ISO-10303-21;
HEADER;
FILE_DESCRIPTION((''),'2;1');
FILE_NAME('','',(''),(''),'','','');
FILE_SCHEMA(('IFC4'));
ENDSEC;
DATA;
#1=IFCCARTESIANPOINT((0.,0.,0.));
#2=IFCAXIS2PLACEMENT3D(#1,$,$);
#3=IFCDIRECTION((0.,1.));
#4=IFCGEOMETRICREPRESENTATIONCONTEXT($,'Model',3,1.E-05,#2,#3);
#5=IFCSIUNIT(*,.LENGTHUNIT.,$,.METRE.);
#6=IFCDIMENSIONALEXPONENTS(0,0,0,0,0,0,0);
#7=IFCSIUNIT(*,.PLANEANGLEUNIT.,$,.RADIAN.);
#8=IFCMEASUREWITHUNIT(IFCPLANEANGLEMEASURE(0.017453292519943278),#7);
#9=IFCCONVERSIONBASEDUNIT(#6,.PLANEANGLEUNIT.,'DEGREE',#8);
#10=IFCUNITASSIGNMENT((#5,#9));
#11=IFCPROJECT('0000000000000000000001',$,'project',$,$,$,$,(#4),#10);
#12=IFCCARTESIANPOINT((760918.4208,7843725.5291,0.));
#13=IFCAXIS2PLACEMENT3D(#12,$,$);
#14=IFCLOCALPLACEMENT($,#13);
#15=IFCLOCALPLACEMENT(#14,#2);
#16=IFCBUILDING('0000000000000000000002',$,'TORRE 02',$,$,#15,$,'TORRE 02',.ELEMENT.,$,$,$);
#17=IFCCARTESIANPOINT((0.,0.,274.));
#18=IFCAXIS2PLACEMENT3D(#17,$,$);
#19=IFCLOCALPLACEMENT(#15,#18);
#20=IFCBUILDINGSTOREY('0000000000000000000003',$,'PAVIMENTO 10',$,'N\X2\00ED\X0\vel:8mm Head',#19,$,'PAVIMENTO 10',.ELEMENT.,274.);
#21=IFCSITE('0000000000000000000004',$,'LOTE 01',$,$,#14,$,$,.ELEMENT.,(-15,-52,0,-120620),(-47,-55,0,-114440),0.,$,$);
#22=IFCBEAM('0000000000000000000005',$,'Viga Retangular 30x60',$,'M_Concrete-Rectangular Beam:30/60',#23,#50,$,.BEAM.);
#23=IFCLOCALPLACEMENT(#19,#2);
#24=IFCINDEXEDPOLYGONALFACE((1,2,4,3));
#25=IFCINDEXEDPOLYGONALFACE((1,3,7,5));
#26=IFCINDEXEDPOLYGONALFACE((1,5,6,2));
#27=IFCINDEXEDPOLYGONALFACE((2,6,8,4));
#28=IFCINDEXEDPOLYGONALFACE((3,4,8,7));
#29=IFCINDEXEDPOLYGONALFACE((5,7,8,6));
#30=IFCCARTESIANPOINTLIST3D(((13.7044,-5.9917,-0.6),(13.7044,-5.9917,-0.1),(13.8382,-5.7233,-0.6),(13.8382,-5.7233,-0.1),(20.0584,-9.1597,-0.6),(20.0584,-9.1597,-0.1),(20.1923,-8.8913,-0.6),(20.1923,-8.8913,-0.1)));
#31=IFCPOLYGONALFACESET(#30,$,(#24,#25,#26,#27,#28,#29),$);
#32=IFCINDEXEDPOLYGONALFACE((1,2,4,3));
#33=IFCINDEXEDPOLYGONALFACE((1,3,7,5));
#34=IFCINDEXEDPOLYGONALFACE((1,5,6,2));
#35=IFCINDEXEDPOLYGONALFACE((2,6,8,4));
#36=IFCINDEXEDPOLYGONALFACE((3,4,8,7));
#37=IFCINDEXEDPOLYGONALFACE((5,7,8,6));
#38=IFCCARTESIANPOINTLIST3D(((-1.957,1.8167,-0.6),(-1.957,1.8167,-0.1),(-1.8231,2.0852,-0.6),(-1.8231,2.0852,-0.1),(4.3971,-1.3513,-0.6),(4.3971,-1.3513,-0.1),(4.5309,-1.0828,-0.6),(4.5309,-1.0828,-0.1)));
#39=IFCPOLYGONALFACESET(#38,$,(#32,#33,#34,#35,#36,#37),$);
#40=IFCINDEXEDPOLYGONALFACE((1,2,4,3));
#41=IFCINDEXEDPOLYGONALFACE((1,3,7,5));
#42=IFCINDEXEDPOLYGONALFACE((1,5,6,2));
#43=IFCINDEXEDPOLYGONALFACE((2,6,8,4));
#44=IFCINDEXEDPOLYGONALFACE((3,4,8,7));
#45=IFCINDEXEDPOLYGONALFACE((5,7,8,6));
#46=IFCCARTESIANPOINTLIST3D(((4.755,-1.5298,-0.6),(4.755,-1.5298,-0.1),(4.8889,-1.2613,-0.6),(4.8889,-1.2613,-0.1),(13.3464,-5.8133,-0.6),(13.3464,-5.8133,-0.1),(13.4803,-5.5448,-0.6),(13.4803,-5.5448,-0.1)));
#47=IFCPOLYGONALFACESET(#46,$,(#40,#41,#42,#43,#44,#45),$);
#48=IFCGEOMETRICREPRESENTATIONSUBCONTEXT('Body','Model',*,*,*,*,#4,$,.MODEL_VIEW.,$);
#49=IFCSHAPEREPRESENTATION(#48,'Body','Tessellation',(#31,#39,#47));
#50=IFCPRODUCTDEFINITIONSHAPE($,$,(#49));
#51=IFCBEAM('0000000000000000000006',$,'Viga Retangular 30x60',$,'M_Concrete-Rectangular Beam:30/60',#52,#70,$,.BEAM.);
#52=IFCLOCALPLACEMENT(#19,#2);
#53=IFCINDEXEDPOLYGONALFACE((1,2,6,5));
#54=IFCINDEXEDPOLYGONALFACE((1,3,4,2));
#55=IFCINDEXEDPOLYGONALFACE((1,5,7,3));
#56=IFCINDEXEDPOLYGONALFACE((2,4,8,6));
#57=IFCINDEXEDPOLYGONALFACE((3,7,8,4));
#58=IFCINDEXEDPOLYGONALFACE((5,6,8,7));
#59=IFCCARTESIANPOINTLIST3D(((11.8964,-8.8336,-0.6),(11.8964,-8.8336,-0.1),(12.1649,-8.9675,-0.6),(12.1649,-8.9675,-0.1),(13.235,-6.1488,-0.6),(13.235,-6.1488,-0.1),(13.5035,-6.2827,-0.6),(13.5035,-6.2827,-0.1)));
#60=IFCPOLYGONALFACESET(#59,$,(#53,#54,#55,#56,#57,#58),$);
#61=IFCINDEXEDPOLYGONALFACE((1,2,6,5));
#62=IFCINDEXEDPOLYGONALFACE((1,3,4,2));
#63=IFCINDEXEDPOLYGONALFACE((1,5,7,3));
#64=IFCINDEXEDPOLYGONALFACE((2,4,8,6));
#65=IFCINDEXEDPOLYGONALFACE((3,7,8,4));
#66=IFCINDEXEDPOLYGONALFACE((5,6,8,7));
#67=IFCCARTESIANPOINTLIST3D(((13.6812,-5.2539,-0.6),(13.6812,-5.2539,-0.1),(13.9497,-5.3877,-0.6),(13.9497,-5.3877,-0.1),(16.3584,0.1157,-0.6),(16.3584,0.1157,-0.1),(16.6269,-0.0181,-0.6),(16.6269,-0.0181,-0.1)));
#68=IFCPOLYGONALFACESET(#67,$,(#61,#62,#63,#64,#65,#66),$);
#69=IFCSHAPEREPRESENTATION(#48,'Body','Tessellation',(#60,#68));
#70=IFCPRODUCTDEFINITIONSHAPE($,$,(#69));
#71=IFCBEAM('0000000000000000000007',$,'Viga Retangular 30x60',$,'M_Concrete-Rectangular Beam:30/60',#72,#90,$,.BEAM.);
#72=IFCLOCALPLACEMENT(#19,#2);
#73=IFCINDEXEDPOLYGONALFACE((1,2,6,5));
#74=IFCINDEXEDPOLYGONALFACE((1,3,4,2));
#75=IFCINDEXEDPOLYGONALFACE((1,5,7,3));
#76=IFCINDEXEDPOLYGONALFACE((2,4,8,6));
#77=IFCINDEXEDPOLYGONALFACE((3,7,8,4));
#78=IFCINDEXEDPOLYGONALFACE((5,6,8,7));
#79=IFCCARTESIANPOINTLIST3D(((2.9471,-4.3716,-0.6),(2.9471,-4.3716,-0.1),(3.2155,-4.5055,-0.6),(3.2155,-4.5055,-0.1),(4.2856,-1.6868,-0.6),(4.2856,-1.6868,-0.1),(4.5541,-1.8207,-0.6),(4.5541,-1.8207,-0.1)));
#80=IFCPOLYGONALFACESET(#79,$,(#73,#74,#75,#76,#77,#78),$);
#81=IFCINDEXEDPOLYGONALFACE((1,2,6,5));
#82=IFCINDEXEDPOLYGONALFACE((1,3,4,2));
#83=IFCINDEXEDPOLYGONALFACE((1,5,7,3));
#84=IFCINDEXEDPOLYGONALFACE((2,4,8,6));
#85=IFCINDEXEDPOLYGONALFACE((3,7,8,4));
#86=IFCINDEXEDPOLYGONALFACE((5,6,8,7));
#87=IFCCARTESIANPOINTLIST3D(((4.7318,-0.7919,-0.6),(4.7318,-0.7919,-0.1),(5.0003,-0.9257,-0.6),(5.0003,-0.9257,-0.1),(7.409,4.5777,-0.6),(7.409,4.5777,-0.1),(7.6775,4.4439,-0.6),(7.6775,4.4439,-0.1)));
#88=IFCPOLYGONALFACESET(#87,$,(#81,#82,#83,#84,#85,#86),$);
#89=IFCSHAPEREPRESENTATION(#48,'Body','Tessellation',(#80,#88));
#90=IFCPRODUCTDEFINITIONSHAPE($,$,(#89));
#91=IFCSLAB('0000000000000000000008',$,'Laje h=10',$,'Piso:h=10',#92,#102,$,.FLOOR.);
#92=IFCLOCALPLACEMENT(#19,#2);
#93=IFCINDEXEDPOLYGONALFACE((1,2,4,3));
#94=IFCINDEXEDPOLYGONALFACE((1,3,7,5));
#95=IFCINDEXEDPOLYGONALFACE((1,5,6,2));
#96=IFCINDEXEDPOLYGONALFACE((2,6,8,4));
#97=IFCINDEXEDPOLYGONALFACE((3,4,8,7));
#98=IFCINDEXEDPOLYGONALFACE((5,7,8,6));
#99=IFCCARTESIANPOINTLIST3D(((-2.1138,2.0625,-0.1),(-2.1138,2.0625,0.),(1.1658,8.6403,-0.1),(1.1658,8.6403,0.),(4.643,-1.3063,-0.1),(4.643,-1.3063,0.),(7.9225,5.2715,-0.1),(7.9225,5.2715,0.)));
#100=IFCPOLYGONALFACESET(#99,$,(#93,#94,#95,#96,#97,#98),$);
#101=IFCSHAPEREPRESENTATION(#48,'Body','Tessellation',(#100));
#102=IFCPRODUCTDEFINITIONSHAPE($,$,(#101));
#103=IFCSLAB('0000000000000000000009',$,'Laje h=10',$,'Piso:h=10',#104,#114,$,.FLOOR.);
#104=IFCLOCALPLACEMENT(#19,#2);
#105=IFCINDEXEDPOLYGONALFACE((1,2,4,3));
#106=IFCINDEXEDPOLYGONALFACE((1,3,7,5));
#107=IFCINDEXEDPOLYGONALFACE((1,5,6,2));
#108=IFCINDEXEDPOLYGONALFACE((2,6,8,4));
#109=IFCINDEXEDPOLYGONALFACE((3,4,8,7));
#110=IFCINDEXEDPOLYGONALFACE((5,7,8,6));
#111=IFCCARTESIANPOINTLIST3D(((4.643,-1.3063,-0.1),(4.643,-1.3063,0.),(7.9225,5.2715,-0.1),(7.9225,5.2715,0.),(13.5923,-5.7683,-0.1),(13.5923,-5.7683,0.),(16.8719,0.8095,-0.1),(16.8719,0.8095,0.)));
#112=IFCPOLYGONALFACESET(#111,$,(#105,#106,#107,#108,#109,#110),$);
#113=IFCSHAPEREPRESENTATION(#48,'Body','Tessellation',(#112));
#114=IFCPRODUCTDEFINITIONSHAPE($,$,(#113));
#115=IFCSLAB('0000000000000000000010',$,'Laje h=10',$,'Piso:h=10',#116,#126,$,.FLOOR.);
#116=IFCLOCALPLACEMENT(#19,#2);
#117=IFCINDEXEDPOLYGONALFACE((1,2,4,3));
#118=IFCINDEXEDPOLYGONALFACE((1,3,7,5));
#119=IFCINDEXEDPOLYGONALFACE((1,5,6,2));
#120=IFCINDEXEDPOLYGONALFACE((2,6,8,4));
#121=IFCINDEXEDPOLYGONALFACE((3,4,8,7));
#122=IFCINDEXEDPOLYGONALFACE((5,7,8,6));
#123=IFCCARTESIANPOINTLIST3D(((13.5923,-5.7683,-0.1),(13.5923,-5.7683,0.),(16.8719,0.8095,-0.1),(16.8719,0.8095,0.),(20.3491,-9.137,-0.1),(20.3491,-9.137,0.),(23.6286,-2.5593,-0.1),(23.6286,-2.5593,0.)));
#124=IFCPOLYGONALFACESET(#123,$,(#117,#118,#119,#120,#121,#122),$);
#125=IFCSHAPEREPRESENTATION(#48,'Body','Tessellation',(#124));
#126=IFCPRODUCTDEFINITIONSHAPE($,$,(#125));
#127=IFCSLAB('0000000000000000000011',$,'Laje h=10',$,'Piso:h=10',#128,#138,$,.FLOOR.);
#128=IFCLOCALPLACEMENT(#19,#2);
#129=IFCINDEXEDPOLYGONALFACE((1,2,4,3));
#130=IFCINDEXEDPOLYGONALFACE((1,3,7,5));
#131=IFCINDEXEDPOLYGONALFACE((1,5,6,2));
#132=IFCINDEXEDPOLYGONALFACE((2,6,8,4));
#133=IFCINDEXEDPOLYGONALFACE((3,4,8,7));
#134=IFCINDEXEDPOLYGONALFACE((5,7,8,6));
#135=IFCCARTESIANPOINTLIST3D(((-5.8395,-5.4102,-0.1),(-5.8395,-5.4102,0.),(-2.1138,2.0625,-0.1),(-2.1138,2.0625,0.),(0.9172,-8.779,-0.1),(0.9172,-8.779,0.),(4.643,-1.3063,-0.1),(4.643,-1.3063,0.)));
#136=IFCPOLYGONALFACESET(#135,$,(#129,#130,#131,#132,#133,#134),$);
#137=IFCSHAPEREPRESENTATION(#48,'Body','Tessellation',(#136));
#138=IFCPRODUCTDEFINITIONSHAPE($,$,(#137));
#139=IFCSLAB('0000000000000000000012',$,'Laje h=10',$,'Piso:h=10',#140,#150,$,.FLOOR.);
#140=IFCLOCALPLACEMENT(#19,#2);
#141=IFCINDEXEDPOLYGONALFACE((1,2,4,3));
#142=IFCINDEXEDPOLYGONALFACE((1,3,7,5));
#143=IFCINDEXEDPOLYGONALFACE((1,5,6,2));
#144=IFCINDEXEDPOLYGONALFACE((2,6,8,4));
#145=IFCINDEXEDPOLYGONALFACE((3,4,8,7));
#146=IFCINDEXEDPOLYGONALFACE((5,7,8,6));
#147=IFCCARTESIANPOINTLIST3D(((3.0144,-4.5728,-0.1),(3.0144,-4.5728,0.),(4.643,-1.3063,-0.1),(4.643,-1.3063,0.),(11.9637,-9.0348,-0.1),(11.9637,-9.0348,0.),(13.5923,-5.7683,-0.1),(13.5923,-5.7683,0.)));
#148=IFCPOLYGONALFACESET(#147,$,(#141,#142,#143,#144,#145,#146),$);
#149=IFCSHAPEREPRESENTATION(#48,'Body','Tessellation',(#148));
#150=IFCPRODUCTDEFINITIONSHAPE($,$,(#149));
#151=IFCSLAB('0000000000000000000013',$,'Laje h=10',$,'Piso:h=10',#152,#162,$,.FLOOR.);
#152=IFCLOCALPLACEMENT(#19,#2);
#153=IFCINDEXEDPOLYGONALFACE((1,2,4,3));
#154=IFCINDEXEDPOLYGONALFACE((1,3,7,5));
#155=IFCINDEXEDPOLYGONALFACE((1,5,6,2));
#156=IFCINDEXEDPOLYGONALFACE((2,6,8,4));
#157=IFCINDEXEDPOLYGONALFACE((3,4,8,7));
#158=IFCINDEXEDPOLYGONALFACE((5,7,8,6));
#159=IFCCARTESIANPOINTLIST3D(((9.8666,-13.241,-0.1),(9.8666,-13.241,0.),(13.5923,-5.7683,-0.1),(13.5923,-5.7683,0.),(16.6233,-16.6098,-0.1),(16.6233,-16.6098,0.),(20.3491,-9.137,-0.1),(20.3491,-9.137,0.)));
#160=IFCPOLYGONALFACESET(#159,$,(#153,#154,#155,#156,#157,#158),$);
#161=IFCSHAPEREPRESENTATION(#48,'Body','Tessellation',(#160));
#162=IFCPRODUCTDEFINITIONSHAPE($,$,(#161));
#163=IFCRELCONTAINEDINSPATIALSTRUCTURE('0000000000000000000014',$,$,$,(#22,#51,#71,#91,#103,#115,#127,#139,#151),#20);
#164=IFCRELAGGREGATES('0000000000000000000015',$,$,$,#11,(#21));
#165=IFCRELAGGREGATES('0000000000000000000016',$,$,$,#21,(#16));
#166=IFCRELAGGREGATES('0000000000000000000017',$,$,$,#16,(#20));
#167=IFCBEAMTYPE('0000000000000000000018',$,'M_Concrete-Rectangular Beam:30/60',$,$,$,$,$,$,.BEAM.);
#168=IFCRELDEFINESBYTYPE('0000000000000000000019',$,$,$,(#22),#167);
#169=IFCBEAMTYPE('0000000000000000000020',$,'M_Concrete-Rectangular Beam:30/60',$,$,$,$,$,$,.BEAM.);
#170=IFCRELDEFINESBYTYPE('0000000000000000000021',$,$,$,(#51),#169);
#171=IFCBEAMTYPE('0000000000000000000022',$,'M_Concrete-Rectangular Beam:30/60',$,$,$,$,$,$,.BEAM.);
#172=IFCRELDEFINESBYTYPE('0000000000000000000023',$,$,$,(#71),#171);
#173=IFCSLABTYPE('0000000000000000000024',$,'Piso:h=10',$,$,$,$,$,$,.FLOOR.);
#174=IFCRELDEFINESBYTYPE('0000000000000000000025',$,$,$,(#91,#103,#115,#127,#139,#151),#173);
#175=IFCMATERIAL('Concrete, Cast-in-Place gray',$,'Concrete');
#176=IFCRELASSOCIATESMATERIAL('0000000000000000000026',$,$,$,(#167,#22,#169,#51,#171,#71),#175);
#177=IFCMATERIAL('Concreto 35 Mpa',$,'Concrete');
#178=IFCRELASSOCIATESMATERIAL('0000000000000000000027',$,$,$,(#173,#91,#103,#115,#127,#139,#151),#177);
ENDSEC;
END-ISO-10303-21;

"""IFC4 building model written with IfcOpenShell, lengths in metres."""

from ifc_helpers import new_model, entity, si_unit, converted_unit, direction, frame, origin, place, context, subcontext, project, spatial, indexed_curve, outline, extrude, source, transform, mapped, material, type_object, type_shapes, element, save


model = new_model("IFC4")

# Units and contexts
model_context = context("Model", 3, precision=1e-05, world=origin(), true_north=direction((0.0, 1.0)))
body_context = subcontext(model_context, "Body", "Model", "MODEL_VIEW")
ifc_project = project(units=[si_unit("LENGTHUNIT", "METRE"), converted_unit("PLANEANGLEUNIT", "DEGREE", entity("IfcPlaneAngleMeasure", 0.017453292519943278), si_unit("PLANEANGLEUNIT", "RADIAN"), dimensions=[0, 0, 0, 0, 0, 0, 0])], contexts=[model_context])

# Site, building, storey
site_placement = place(None, frame((760918.4208, 7843725.5291, 0.0)))
site = spatial("IfcSite", under=ifc_project, at=site_placement, Name="LOTE 01", CompositionType="ELEMENT", RefLatitude=(-15, -52, 0, -120620), RefLongitude=(-47, -55, 0, -114440), RefElevation=0.0)
building_placement = place(site_placement, origin())
building = spatial("IfcBuilding", under=site, at=building_placement, Name="TORRE 02", LongName="TORRE 02", CompositionType="ELEMENT")
storey_placement = place(building_placement, frame((0.0, 0.0, 274.0)))
storey = spatial("IfcBuildingStorey", under=building, at=storey_placement, Name="PAVIMENTO 10", ObjectType="Nível:8mm Head", LongName="PAVIMENTO 10", CompositionType="ELEMENT", Elevation=274.0)

# Shared definitions
ifc_material_1 = material(Name="Concrete, Cast-in-Place gray", Category="Concrete")

# Beams
beam_type_1 = type_object("IfcBeamType", Name="M_Concrete-Rectangular Beam:30/60", PredefinedType="BEAM", material=ifc_material_1)
shared_shape_1 = source(origin(), body_context, "Body", "SweptSolid", [
    extrude(outline(indexed_curve([(-0.25, -0.15), (0.25, -0.15), (0.25, 0.15), (-0.25, 0.15), (-0.25, -0.15)], self_intersect=False)), frame((13.7713, -5.8575, 273.65), z_axis=(0.894934, -0.446198, 0.0), x_axis=(0.0, 0.0, -1.0)), (0.0, 0.0, 1.0), 7.1),
    extrude(outline(indexed_curve([(-0.25, -0.15), (0.25, -0.15), (0.25, 0.15), (-0.25, 0.15), (-0.25, -0.15)], self_intersect=False)), frame((-1.89, 1.951, 273.65), z_axis=(0.894934, -0.446198, 0.0), x_axis=(0.0, 0.0, -1.0)), (0.0, 0.0, 1.0), 7.1),
    extrude(outline(indexed_curve([(-0.25, -0.15), (0.25, -0.15), (0.25, 0.15), (-0.25, 0.15), (-0.25, -0.15)], self_intersect=False)), frame((4.822, -1.3955, 273.65), z_axis=(0.894934, -0.446198, 0.0), x_axis=(0.0, 0.0, -1.0)), (0.0, 0.0, 1.0), 9.6),
])
type_shapes(beam_type_1, [shared_shape_1])
beam_1_placement = place(storey_placement, frame((0.0, 0.0, -274.0)))
element("IfcBeam", 1, at=beam_1_placement, inside=storey, type_object=beam_type_1, material=ifc_material_1, Name="Viga Retangular 30x60", ObjectType="M_Concrete-Rectangular Beam:30/60", PredefinedType="BEAM", context=body_context, shape_type="MappedRepresentation", body=[
    mapped(shared_shape_1, transform((0.0, 0.0, 0.0), scale=1.0)),
])
beam_type_2 = type_object("IfcBeamType", Name="M_Concrete-Rectangular Beam:30/60", PredefinedType="BEAM", material=ifc_material_1)
shared_shape_2 = source(origin(), body_context, "Body", "SweptSolid", [
    extrude(outline(indexed_curve([(-0.25, -0.15), (0.25, -0.15), (0.25, 0.15), (-0.25, 0.15), (-0.25, -0.15)], self_intersect=False)), frame((12.0306, -8.9005, 273.65), z_axis=(0.446198, 0.894934, 0.0), x_axis=(0.0, 0.0, 1.0)), (0.0, 0.0, 1.0), 3.0),
    extrude(outline(indexed_curve([(-0.25, -0.15), (0.25, -0.15), (0.25, 0.15), (-0.25, 0.15), (-0.25, -0.15)], self_intersect=False)), frame((13.8154, -5.3208, 273.65), z_axis=(0.446198, 0.894934, 0.0), x_axis=(0.0, 0.0, 1.0)), (0.0, 0.0, 1.0), 6.0),
])
type_shapes(beam_type_2, [shared_shape_2])
beam_2_placement = place(storey_placement, frame((0.0, 0.0, -274.0)))
element("IfcBeam", 2, at=beam_2_placement, inside=storey, type_object=beam_type_2, material=ifc_material_1, Name="Viga Retangular 30x60", ObjectType="M_Concrete-Rectangular Beam:30/60", PredefinedType="BEAM", context=body_context, shape_type="MappedRepresentation", body=[
    mapped(shared_shape_2, transform((0.0, 0.0, 0.0), scale=1.0)),
])
beam_type_3 = type_object("IfcBeamType", Name="M_Concrete-Rectangular Beam:30/60", PredefinedType="BEAM", material=ifc_material_1)
shared_shape_3 = source(origin(), body_context, "Body", "SweptSolid", [
    extrude(outline(indexed_curve([(-0.25, -0.15), (0.25, -0.15), (0.25, 0.15), (-0.25, 0.15), (-0.25, -0.15)], self_intersect=False)), frame((3.0813, -4.4385, 273.65), z_axis=(0.446198, 0.894934, 0.0), x_axis=(0.0, 0.0, 1.0)), (0.0, 0.0, 1.0), 3.0),
    extrude(outline(indexed_curve([(-0.25, -0.15), (0.25, -0.15), (0.25, 0.15), (-0.25, 0.15), (-0.25, -0.15)], self_intersect=False)), frame((4.8661, -0.8588, 273.65), z_axis=(0.446198, 0.894934, 0.0), x_axis=(0.0, 0.0, 1.0)), (0.0, 0.0, 1.0), 6.0),
])
type_shapes(beam_type_3, [shared_shape_3])
beam_3_placement = place(storey_placement, frame((0.0, 0.0, -274.0)))
element("IfcBeam", 3, at=beam_3_placement, inside=storey, type_object=beam_type_3, material=ifc_material_1, Name="Viga Retangular 30x60", ObjectType="M_Concrete-Rectangular Beam:30/60", PredefinedType="BEAM", context=body_context, shape_type="MappedRepresentation", body=[
    mapped(shared_shape_3, transform((0.0, 0.0, 0.0), scale=1.0)),
])

# Slabs
ifc_material_2 = material(Name="Concreto 35 Mpa", Category="Concrete")
slab_type = type_object("IfcSlabType", Name="Piso:h=10", PredefinedType="FLOOR", material=ifc_material_2)
slab_1_placement = place(storey_placement, origin())
element("IfcSlab", 4, at=slab_1_placement, inside=storey, type_object=slab_type, material=ifc_material_2, Name="Laje h=10", ObjectType="Piso:h=10", PredefinedType="FLOOR", context=body_context, shape_type="SweptSolid", body=[
    extrude(outline(indexed_curve([(-3.675, -3.775), (3.675, -3.775), (3.675, 3.775), (-3.675, 3.775), (-3.675, -3.775)], self_intersect=False)), frame((2.9044, 3.667, 0.0), z_axis=(0.0, 0.0, -1.0), x_axis=(-0.446198, -0.894934, 0.0)), (0.0, 0.0, 1.0), 0.1),
])
slab_2_placement = place(storey_placement, origin())
element("IfcSlab", 5, at=slab_2_placement, inside=storey, type_object=slab_type, material=ifc_material_2, Name="Laje h=10", ObjectType="Piso:h=10", PredefinedType="FLOOR", context=body_context, shape_type="SweptSolid", body=[
    extrude(outline(indexed_curve([(-3.675, -5.0), (3.675, -5.0), (3.675, 5.0), (-3.675, 5.0), (-3.675, -5.0)], self_intersect=False)), frame((10.7574, -0.2484, 0.0), z_axis=(0.0, 0.0, -1.0), x_axis=(-0.446198, -0.894934, 0.0)), (0.0, 0.0, 1.0), 0.1),
])
slab_3_placement = place(storey_placement, origin())
element("IfcSlab", 6, at=slab_3_placement, inside=storey, type_object=slab_type, material=ifc_material_2, Name="Laje h=10", ObjectType="Piso:h=10", PredefinedType="FLOOR", context=body_context, shape_type="SweptSolid", body=[
    extrude(outline(indexed_curve([(-3.675, -3.775), (3.675, -3.775), (3.675, 3.775), (-3.675, 3.775), (-3.675, -3.775)], self_intersect=False)), frame((18.6105, -4.1638, 0.0), z_axis=(0.0, 0.0, -1.0), x_axis=(-0.446198, -0.894934, 0.0)), (0.0, 0.0, 1.0), 0.1),
])
slab_4_placement = place(storey_placement, origin())
element("IfcSlab", 7, at=slab_4_placement, inside=storey, type_object=slab_type, material=ifc_material_2, Name="Laje h=10", ObjectType="Piso:h=10", PredefinedType="FLOOR", context=body_context, shape_type="SweptSolid", body=[
    extrude(outline(indexed_curve([(-4.175, -3.775), (4.175, -3.775), (4.175, 3.775), (-4.175, 3.775), (-4.175, -3.775)], self_intersect=False)), frame((-0.5983, -3.3582, 0.0), z_axis=(0.0, 0.0, -1.0), x_axis=(-0.446198, -0.894934, 0.0)), (0.0, 0.0, 1.0), 0.1),
])
slab_5_placement = place(storey_placement, origin())
element("IfcSlab", 8, at=slab_5_placement, inside=storey, type_object=slab_type, material=ifc_material_2, Name="Laje h=10", ObjectType="Piso:h=10", PredefinedType="FLOOR", context=body_context, shape_type="SweptSolid", body=[
    extrude(outline(indexed_curve([(-1.825, -5.0), (1.825, -5.0), (1.825, 5.0), (-1.825, 5.0), (-1.825, -5.0)], self_intersect=False)), frame((8.3033, -5.1705, 0.0), z_axis=(0.0, 0.0, -1.0), x_axis=(-0.446198, -0.894934, 0.0)), (0.0, 0.0, 1.0), 0.1),
])
slab_6_placement = place(storey_placement, origin())
element("IfcSlab", 9, at=slab_6_placement, inside=storey, type_object=slab_type, material=ifc_material_2, Name="Laje h=10", ObjectType="Piso:h=10", PredefinedType="FLOOR", context=body_context, shape_type="SweptSolid", body=[
    extrude(outline(indexed_curve([(-4.175, -3.775), (4.175, -3.775), (4.175, 3.775), (-4.175, 3.775), (-4.175, -3.775)], self_intersect=False)), frame((15.1078, -11.189, 0.0), z_axis=(0.0, 0.0, -1.0), x_axis=(-0.446198, -0.894934, 0.0)), (0.0, 0.0, 1.0), 0.1),
])

save(model, "model.ifc")
